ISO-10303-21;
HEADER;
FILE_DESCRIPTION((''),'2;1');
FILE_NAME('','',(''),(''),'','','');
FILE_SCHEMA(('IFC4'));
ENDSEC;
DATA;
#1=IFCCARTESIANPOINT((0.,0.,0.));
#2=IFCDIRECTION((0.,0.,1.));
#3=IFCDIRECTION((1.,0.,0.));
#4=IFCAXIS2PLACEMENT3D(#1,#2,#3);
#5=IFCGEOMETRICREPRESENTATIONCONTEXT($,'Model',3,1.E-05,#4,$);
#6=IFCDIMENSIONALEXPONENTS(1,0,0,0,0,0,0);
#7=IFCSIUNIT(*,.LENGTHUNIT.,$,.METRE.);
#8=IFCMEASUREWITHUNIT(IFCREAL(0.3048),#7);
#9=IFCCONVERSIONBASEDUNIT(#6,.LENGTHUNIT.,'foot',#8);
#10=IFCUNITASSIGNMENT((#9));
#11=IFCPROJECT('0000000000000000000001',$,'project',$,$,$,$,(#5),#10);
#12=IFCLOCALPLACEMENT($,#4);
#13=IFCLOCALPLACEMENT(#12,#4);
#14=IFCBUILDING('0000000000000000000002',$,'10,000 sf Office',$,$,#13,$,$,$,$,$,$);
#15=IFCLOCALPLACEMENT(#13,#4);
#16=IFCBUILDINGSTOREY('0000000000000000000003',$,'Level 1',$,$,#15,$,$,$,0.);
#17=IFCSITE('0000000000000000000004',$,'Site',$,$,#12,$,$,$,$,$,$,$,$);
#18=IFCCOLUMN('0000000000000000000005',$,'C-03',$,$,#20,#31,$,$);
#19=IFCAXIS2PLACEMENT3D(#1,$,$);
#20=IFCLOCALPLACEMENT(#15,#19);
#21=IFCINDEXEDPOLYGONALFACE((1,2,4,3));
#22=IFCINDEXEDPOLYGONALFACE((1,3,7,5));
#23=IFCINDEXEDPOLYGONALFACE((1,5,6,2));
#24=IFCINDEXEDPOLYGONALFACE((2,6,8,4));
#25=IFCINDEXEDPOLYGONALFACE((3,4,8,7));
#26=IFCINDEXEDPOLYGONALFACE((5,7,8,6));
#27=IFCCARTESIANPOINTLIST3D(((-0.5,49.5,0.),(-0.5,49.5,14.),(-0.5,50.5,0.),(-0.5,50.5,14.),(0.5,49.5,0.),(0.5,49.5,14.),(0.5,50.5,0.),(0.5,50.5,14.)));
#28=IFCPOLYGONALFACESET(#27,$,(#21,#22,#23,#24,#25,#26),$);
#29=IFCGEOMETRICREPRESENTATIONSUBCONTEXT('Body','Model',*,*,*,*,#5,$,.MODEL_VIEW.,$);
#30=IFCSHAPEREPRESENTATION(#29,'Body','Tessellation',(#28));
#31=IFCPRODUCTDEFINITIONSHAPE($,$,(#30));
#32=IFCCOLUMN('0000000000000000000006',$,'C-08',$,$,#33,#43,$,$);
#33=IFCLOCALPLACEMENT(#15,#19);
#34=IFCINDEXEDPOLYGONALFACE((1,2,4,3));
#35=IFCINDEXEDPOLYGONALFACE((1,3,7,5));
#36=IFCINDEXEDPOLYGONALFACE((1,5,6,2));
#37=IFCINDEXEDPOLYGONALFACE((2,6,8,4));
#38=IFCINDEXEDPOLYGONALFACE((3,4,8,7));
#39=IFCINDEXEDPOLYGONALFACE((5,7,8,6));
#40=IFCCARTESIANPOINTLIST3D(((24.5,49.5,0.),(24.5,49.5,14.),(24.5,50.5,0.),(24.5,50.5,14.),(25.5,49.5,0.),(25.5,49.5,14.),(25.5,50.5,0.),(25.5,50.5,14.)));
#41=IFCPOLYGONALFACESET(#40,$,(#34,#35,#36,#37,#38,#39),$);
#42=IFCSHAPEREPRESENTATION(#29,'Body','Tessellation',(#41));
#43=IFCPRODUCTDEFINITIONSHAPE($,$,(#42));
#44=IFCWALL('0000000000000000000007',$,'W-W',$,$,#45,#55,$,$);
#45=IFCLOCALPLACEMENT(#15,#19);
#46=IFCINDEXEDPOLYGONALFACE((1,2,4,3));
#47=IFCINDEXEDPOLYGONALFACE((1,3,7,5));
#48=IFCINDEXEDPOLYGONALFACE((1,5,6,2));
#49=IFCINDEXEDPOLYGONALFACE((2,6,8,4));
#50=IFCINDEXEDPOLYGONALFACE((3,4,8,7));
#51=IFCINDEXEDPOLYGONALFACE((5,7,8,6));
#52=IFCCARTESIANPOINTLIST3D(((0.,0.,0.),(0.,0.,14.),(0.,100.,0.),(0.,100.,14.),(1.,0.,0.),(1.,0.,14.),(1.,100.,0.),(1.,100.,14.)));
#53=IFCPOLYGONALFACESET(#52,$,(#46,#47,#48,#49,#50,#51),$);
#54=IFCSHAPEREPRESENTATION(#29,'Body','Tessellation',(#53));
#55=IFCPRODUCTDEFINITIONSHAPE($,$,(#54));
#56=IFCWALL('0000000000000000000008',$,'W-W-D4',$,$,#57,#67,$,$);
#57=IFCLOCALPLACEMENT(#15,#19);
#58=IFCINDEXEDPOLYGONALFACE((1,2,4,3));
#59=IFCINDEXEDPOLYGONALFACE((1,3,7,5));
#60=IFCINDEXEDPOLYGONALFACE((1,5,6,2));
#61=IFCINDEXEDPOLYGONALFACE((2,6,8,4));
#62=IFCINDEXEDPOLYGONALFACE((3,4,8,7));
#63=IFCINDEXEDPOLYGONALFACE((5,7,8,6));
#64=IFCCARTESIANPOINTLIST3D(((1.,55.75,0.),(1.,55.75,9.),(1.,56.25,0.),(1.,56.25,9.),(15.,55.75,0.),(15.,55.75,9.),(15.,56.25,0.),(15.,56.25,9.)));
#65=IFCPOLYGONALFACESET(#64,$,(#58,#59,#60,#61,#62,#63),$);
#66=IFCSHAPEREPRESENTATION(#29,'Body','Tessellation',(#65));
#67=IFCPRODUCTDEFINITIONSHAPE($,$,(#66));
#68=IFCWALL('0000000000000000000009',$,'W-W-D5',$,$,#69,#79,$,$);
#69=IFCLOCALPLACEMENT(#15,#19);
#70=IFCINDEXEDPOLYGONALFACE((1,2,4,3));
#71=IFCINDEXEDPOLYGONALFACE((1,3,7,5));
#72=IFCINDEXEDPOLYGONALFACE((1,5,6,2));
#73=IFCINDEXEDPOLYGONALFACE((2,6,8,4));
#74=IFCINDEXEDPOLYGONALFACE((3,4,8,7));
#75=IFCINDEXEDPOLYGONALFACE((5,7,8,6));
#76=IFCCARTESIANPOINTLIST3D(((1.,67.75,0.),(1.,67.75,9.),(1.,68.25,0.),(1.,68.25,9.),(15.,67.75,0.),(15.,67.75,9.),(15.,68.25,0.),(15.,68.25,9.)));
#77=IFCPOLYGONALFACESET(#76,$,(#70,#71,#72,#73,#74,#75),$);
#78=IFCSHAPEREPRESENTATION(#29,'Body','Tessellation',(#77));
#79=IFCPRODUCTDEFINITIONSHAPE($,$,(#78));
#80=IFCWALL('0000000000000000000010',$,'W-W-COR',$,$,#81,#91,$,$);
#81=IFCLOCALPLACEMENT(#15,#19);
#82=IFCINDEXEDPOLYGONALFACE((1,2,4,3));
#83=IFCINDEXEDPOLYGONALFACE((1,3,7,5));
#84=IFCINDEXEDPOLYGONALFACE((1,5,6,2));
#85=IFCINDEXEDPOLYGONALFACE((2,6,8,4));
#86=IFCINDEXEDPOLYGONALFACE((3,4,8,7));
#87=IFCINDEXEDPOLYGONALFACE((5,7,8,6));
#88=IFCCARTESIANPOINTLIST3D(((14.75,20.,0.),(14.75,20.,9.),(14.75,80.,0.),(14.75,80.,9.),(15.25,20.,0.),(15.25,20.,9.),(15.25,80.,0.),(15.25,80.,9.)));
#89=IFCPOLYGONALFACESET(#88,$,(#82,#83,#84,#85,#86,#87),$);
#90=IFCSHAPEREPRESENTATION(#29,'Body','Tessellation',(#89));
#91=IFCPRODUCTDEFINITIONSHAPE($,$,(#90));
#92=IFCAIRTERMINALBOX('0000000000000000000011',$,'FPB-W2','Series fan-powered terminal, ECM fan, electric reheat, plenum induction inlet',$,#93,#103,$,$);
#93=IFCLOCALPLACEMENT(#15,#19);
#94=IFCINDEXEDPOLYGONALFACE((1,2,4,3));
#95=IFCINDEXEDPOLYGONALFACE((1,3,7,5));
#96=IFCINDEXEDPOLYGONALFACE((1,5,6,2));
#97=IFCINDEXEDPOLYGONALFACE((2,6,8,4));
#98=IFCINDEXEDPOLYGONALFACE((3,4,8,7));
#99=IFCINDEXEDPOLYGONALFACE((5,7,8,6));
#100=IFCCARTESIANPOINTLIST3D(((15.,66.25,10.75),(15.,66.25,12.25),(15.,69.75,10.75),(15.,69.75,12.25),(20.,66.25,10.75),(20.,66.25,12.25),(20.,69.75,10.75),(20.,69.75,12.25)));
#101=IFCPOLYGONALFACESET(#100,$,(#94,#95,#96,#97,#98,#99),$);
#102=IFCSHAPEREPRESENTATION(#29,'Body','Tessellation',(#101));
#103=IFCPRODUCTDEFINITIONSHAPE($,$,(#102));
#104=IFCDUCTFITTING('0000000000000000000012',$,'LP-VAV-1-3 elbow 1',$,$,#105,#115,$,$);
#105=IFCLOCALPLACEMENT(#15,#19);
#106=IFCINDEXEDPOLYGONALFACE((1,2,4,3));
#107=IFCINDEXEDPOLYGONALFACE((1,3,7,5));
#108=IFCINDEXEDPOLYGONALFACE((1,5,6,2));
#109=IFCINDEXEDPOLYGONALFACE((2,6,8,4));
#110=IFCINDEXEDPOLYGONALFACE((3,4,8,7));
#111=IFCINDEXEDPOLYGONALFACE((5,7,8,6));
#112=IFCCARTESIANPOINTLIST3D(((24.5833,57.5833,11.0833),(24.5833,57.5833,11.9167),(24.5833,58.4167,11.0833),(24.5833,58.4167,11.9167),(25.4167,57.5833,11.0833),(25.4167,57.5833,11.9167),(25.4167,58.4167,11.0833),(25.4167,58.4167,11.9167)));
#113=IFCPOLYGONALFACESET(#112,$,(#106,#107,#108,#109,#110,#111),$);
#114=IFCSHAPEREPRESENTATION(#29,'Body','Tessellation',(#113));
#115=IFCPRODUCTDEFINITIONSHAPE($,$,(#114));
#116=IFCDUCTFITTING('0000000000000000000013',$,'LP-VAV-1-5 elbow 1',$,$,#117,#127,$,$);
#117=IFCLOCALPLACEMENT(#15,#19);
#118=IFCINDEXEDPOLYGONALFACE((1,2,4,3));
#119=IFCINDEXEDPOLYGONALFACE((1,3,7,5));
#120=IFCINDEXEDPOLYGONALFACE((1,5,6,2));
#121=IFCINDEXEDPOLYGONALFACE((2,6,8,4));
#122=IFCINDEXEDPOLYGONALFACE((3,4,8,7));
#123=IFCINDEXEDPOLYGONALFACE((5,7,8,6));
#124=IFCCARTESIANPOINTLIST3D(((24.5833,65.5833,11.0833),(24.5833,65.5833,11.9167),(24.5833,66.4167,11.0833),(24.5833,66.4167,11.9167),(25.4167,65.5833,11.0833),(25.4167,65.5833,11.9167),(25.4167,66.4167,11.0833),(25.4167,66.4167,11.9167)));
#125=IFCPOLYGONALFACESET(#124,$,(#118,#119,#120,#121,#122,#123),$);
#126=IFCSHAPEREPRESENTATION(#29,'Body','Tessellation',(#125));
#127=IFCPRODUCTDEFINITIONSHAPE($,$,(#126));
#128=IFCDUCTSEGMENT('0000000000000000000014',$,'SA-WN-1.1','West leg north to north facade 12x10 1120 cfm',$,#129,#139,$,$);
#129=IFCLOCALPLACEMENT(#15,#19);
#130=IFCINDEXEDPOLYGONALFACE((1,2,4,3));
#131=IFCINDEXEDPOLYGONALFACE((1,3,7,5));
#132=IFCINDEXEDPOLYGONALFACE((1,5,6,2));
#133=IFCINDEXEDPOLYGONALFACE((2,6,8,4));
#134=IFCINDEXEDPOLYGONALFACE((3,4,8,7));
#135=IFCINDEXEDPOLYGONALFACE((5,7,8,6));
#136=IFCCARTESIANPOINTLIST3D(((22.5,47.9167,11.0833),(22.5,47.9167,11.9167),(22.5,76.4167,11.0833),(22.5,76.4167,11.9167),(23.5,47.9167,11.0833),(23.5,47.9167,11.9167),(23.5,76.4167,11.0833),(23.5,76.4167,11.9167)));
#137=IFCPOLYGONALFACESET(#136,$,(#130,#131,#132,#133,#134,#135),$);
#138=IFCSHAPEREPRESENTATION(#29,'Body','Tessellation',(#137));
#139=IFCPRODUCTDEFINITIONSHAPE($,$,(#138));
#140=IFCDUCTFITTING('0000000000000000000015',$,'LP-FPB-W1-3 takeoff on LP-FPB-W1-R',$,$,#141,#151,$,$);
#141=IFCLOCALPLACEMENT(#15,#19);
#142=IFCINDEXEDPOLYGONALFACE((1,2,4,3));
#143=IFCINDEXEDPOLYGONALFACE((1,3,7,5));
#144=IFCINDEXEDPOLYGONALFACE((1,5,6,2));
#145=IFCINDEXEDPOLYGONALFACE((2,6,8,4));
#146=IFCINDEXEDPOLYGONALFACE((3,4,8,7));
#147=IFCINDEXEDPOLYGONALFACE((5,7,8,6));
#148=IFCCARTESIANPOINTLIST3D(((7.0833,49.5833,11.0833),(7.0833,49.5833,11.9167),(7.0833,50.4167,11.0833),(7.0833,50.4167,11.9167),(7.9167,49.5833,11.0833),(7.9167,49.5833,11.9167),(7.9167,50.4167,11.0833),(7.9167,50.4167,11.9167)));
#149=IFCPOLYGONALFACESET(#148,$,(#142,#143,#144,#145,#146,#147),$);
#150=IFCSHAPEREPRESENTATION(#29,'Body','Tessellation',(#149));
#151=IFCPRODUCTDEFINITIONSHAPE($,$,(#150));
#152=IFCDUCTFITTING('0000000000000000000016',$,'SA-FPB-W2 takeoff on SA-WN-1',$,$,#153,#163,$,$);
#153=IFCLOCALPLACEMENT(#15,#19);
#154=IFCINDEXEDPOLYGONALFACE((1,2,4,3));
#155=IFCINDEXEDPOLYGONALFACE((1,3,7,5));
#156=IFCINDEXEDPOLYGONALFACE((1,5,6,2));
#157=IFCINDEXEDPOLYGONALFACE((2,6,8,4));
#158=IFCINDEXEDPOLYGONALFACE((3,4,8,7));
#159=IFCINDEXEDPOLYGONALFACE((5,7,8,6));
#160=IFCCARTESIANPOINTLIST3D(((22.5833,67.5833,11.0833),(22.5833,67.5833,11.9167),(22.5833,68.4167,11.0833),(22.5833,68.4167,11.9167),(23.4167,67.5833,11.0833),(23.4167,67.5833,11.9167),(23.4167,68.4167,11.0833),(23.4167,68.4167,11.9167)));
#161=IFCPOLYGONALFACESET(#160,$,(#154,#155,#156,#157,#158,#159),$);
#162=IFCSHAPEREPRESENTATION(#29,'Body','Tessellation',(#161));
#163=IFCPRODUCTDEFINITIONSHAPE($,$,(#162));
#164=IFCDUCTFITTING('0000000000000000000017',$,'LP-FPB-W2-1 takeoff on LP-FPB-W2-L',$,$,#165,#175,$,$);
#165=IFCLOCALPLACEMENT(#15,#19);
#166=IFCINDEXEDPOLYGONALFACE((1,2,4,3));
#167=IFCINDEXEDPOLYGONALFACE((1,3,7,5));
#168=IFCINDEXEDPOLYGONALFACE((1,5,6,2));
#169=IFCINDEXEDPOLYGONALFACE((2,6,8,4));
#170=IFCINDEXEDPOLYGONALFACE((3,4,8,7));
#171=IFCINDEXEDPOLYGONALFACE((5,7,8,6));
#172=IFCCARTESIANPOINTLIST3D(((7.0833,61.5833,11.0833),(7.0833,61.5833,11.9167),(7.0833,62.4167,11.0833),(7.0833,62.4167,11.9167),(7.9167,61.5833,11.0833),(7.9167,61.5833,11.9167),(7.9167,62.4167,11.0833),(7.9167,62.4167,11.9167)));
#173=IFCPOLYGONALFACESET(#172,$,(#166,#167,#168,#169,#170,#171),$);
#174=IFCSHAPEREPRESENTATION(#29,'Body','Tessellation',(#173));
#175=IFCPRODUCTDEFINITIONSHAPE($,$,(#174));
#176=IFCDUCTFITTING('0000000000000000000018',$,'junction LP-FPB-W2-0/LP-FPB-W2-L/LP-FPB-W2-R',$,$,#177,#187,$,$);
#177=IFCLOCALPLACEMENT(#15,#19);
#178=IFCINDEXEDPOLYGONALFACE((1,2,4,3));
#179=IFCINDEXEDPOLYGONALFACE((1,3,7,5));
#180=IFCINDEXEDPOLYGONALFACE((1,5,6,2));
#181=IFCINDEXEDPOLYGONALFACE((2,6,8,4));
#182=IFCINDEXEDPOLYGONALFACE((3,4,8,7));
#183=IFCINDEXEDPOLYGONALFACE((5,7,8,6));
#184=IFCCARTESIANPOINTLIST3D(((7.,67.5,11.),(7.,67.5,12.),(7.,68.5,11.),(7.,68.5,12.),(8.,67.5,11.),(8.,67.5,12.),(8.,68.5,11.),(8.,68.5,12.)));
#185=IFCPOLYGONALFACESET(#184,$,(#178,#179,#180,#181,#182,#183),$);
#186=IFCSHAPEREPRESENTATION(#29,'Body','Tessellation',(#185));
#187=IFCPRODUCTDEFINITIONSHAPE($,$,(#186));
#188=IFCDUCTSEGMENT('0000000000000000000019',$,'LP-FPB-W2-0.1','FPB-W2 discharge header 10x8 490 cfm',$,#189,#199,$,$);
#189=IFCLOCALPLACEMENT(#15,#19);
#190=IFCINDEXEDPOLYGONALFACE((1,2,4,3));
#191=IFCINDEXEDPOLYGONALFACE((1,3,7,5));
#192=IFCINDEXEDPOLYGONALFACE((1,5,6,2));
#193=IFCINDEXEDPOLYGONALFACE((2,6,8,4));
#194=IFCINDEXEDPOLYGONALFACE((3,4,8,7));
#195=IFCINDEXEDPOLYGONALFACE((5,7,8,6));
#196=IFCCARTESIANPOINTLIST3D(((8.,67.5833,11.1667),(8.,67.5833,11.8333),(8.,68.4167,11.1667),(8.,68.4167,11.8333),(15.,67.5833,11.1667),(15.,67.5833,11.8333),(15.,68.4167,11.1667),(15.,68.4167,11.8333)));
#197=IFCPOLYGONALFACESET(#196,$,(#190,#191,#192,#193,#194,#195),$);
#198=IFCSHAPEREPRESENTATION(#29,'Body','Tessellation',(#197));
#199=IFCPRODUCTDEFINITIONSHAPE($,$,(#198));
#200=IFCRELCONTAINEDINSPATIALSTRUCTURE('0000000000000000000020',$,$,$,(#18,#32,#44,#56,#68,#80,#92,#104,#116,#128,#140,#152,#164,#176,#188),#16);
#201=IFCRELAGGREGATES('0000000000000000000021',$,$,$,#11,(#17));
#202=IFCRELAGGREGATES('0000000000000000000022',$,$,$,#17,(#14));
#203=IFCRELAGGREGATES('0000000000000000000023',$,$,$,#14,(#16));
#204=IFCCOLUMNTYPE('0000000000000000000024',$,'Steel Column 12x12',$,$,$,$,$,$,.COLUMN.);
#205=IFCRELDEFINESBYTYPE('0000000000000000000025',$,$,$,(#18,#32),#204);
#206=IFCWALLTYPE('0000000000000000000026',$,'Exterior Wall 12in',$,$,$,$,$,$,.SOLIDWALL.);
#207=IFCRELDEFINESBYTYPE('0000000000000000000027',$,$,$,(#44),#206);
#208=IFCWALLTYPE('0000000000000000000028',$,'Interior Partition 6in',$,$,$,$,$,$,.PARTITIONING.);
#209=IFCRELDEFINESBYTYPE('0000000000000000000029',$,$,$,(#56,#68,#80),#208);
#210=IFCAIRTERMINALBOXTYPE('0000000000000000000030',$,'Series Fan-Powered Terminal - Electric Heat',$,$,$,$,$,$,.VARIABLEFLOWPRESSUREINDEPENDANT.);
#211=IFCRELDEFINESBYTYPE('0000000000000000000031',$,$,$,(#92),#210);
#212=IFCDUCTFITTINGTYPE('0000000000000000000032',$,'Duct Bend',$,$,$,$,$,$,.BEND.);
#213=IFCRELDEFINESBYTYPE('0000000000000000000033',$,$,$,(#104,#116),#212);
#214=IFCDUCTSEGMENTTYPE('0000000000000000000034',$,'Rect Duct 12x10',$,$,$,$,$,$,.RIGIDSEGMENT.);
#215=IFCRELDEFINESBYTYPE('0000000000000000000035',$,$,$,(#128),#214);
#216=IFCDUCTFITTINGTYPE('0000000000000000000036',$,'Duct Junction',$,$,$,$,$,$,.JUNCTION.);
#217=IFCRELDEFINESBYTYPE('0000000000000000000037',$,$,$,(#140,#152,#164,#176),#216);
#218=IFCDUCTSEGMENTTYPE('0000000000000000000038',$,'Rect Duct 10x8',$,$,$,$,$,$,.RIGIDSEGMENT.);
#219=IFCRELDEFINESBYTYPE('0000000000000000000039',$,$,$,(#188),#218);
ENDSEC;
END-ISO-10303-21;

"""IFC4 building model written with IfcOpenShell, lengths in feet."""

from ifc_helpers import new_model, entity, si_unit, converted_unit, frame, origin_with_axes, place, context, subcontext, project, spatial, rectangle, extrude, type_object, element, save


model = new_model("IFC4")

# Units and contexts
model_context = context("Model", 3, precision=1e-05, world=origin_with_axes())
body_context = subcontext(model_context, "Body", "Model", "MODEL_VIEW")
ifc_project = project(units=[converted_unit("LENGTHUNIT", "foot", entity("IfcReal", 0.3048), si_unit("LENGTHUNIT", "METRE"), dimensions=[1, 0, 0, 0, 0, 0, 0])], contexts=[model_context])

# Site, building, storey
site_placement = place(None, origin_with_axes())
site = spatial("IfcSite", under=ifc_project, at=site_placement, Name="Site")
building_placement = place(site_placement, origin_with_axes())
building = spatial("IfcBuilding", under=site, at=building_placement, Name="10,000 sf Office")
storey_placement = place(building_placement, origin_with_axes())
storey = spatial("IfcBuildingStorey", under=building, at=storey_placement, Name="Level 1", Elevation=0.0)

# Columns
column_type = type_object("IfcColumnType", Name="Steel Column 12x12", PredefinedType="COLUMN")
for number, where, z_axis, x_axis, name in (
    (1, (0.0, 50.0, 0.0), (0.0, 0.0, 1.0), (1.0, 0.0, 0.0), "C-03"),
    (2, (25.0, 50.0, 0.0), (0.0, 0.0, 1.0), (1.0, 0.0, 0.0), "C-08"),
):
    element("IfcColumn", number, at=place(storey_placement, frame(where, z_axis=z_axis, x_axis=x_axis)), inside=storey, type_object=column_type, Name=name, context=body_context, shape_type="SweptSolid", body=[
        extrude(rectangle(XDim=1.0, YDim=1.0), None, (0.0, 0.0, 1.0), 14.0),
    ])

# Walls
wall_type_1 = type_object("IfcWallType", Name="Exterior Wall 12in", PredefinedType="SOLIDWALL")
wall_1_placement = place(storey_placement, frame((0.5, 50.0, 0.0), z_axis=(0.0, 0.0, 1.0), x_axis=(0.0, -1.0, 0.0)))
element("IfcWall", 3, at=wall_1_placement, inside=storey, type_object=wall_type_1, Name="W-W", context=body_context, shape_type="SweptSolid", body=[
    extrude(rectangle(XDim=100.0, YDim=1.0), None, (0.0, 0.0, 1.0), 14.0),
])
wall_type_2 = type_object("IfcWallType", Name="Interior Partition 6in", PredefinedType="PARTITIONING")
for number, where, z_axis, x_axis, name in (
    (4, (8.0, 56.0, 0.0), (0.0, 0.0, 1.0), (1.0, 0.0, 0.0), "W-W-D4"),
    (5, (8.0, 68.0, 0.0), (0.0, 0.0, 1.0), (1.0, 0.0, 0.0), "W-W-D5"),
):
    element("IfcWall", number, at=place(storey_placement, frame(where, z_axis=z_axis, x_axis=x_axis)), inside=storey, type_object=wall_type_2, Name=name, context=body_context, shape_type="SweptSolid", body=[
        extrude(rectangle(XDim=14.0, YDim=0.5), None, (0.0, 0.0, 1.0), 9.0),
    ])
wall_2_placement = place(storey_placement, frame((15.0, 50.0, 0.0), z_axis=(0.0, 0.0, 1.0), x_axis=(0.0, 1.0, 0.0)))
element("IfcWall", 6, at=wall_2_placement, inside=storey, type_object=wall_type_2, Name="W-W-COR", context=body_context, shape_type="SweptSolid", body=[
    extrude(rectangle(XDim=60.0, YDim=0.5), None, (0.0, 0.0, 1.0), 9.0),
])

# Air terminal box
air_terminal_box_type = type_object("IfcAirTerminalBoxType", Name="Series Fan-Powered Terminal - Electric Heat", PredefinedType="VARIABLEFLOWPRESSUREINDEPENDANT")
air_terminal_box_placement = place(storey_placement, frame((17.5, 68.0, 10.75), z_axis=(0.0, 0.0, 1.0), x_axis=(-1.0, 0.0, 0.0)))
element("IfcAirTerminalBox", 7, at=air_terminal_box_placement, inside=storey, type_object=air_terminal_box_type, Name="FPB-W2", Description="Series fan-powered terminal, ECM fan, electric reheat, plenum induction inlet", context=body_context, shape_type="SweptSolid", body=[
    extrude(rectangle(XDim=5.0, YDim=3.5), None, (0.0, 0.0, 1.0), 1.5),
])

# Duct fittings
duct_fitting_type_1 = type_object("IfcDuctFittingType", Name="Duct Bend", PredefinedType="BEND")
for number, where, z_axis, x_axis, name in (
    (8, (25.0, 58.0, 11.0833), (0.0, 0.0, 1.0), (1.0, 0.0, 0.0), "LP-VAV-1-3 elbow 1"),
    (9, (25.0, 66.0, 11.0833), (0.0, 0.0, 1.0), (1.0, 0.0, 0.0), "LP-VAV-1-5 elbow 1"),
):
    element("IfcDuctFitting", number, at=place(storey_placement, frame(where, z_axis=z_axis, x_axis=x_axis)), inside=storey, type_object=duct_fitting_type_1, Name=name, context=body_context, shape_type="SweptSolid", body=[
        extrude(rectangle(XDim=0.8333, YDim=0.8333), None, (0.0, 0.0, 1.0), 0.8333),
    ])

# Duct segment
duct_segment_type_1 = type_object("IfcDuctSegmentType", Name="Rect Duct 12x10", PredefinedType="RIGIDSEGMENT")
duct_segment_1_placement = place(storey_placement, frame((23.0, 47.9167, 11.5), z_axis=(0.0, 1.0, 0.0), x_axis=(-1.0, 0.0, 0.0)))
element("IfcDuctSegment", 10, at=duct_segment_1_placement, inside=storey, type_object=duct_segment_type_1, Name="SA-WN-1.1", Description="West leg north to north facade 12x10 1120 cfm", context=body_context, shape_type="SweptSolid", body=[
    extrude(rectangle(XDim=1.0, YDim=0.8333), None, (0.0, 0.0, 1.0), 28.5),
])

# Duct fittings
duct_fitting_type_2 = type_object("IfcDuctFittingType", Name="Duct Junction", PredefinedType="JUNCTION")
for number, where, z_axis, x_axis, name in (
    (11, (7.5, 50.0, 11.0833), (0.0, 0.0, 1.0), (1.0, 0.0, 0.0), "LP-FPB-W1-3 takeoff on LP-FPB-W1-R"),
    (12, (23.0, 68.0, 11.0833), (0.0, 0.0, 1.0), (1.0, 0.0, 0.0), "SA-FPB-W2 takeoff on SA-WN-1"),
    (13, (7.5, 62.0, 11.0833), (0.0, 0.0, 1.0), (1.0, 0.0, 0.0), "LP-FPB-W2-1 takeoff on LP-FPB-W2-L"),
):
    element("IfcDuctFitting", number, at=place(storey_placement, frame(where, z_axis=z_axis, x_axis=x_axis)), inside=storey, type_object=duct_fitting_type_2, Name=name, context=body_context, shape_type="SweptSolid", body=[
        extrude(rectangle(XDim=0.8333, YDim=0.8333), None, (0.0, 0.0, 1.0), 0.8333),
    ])
duct_fitting_placement = place(storey_placement, frame((7.5, 68.0, 11.0), z_axis=(0.0, 0.0, 1.0), x_axis=(1.0, 0.0, 0.0)))
element("IfcDuctFitting", 14, at=duct_fitting_placement, inside=storey, type_object=duct_fitting_type_2, Name="junction LP-FPB-W2-0/LP-FPB-W2-L/LP-FPB-W2-R", context=body_context, shape_type="SweptSolid", body=[
    extrude(rectangle(XDim=1.0, YDim=1.0), None, (0.0, 0.0, 1.0), 1.0),
])

# Duct segment
duct_segment_type_2 = type_object("IfcDuctSegmentType", Name="Rect Duct 10x8", PredefinedType="RIGIDSEGMENT")
duct_segment_2_placement = place(storey_placement, frame((15.0, 68.0, 11.5), z_axis=(-1.0, 0.0, 0.0), x_axis=(0.0, -1.0, 0.0)))
element("IfcDuctSegment", 15, at=duct_segment_2_placement, inside=storey, type_object=duct_segment_type_2, Name="LP-FPB-W2-0.1", Description="FPB-W2 discharge header 10x8 490 cfm", context=body_context, shape_type="SweptSolid", body=[
    extrude(rectangle(XDim=0.8333, YDim=0.6667), None, (0.0, 0.0, 1.0), 7.0),
])

save(model, "model.ifc")
